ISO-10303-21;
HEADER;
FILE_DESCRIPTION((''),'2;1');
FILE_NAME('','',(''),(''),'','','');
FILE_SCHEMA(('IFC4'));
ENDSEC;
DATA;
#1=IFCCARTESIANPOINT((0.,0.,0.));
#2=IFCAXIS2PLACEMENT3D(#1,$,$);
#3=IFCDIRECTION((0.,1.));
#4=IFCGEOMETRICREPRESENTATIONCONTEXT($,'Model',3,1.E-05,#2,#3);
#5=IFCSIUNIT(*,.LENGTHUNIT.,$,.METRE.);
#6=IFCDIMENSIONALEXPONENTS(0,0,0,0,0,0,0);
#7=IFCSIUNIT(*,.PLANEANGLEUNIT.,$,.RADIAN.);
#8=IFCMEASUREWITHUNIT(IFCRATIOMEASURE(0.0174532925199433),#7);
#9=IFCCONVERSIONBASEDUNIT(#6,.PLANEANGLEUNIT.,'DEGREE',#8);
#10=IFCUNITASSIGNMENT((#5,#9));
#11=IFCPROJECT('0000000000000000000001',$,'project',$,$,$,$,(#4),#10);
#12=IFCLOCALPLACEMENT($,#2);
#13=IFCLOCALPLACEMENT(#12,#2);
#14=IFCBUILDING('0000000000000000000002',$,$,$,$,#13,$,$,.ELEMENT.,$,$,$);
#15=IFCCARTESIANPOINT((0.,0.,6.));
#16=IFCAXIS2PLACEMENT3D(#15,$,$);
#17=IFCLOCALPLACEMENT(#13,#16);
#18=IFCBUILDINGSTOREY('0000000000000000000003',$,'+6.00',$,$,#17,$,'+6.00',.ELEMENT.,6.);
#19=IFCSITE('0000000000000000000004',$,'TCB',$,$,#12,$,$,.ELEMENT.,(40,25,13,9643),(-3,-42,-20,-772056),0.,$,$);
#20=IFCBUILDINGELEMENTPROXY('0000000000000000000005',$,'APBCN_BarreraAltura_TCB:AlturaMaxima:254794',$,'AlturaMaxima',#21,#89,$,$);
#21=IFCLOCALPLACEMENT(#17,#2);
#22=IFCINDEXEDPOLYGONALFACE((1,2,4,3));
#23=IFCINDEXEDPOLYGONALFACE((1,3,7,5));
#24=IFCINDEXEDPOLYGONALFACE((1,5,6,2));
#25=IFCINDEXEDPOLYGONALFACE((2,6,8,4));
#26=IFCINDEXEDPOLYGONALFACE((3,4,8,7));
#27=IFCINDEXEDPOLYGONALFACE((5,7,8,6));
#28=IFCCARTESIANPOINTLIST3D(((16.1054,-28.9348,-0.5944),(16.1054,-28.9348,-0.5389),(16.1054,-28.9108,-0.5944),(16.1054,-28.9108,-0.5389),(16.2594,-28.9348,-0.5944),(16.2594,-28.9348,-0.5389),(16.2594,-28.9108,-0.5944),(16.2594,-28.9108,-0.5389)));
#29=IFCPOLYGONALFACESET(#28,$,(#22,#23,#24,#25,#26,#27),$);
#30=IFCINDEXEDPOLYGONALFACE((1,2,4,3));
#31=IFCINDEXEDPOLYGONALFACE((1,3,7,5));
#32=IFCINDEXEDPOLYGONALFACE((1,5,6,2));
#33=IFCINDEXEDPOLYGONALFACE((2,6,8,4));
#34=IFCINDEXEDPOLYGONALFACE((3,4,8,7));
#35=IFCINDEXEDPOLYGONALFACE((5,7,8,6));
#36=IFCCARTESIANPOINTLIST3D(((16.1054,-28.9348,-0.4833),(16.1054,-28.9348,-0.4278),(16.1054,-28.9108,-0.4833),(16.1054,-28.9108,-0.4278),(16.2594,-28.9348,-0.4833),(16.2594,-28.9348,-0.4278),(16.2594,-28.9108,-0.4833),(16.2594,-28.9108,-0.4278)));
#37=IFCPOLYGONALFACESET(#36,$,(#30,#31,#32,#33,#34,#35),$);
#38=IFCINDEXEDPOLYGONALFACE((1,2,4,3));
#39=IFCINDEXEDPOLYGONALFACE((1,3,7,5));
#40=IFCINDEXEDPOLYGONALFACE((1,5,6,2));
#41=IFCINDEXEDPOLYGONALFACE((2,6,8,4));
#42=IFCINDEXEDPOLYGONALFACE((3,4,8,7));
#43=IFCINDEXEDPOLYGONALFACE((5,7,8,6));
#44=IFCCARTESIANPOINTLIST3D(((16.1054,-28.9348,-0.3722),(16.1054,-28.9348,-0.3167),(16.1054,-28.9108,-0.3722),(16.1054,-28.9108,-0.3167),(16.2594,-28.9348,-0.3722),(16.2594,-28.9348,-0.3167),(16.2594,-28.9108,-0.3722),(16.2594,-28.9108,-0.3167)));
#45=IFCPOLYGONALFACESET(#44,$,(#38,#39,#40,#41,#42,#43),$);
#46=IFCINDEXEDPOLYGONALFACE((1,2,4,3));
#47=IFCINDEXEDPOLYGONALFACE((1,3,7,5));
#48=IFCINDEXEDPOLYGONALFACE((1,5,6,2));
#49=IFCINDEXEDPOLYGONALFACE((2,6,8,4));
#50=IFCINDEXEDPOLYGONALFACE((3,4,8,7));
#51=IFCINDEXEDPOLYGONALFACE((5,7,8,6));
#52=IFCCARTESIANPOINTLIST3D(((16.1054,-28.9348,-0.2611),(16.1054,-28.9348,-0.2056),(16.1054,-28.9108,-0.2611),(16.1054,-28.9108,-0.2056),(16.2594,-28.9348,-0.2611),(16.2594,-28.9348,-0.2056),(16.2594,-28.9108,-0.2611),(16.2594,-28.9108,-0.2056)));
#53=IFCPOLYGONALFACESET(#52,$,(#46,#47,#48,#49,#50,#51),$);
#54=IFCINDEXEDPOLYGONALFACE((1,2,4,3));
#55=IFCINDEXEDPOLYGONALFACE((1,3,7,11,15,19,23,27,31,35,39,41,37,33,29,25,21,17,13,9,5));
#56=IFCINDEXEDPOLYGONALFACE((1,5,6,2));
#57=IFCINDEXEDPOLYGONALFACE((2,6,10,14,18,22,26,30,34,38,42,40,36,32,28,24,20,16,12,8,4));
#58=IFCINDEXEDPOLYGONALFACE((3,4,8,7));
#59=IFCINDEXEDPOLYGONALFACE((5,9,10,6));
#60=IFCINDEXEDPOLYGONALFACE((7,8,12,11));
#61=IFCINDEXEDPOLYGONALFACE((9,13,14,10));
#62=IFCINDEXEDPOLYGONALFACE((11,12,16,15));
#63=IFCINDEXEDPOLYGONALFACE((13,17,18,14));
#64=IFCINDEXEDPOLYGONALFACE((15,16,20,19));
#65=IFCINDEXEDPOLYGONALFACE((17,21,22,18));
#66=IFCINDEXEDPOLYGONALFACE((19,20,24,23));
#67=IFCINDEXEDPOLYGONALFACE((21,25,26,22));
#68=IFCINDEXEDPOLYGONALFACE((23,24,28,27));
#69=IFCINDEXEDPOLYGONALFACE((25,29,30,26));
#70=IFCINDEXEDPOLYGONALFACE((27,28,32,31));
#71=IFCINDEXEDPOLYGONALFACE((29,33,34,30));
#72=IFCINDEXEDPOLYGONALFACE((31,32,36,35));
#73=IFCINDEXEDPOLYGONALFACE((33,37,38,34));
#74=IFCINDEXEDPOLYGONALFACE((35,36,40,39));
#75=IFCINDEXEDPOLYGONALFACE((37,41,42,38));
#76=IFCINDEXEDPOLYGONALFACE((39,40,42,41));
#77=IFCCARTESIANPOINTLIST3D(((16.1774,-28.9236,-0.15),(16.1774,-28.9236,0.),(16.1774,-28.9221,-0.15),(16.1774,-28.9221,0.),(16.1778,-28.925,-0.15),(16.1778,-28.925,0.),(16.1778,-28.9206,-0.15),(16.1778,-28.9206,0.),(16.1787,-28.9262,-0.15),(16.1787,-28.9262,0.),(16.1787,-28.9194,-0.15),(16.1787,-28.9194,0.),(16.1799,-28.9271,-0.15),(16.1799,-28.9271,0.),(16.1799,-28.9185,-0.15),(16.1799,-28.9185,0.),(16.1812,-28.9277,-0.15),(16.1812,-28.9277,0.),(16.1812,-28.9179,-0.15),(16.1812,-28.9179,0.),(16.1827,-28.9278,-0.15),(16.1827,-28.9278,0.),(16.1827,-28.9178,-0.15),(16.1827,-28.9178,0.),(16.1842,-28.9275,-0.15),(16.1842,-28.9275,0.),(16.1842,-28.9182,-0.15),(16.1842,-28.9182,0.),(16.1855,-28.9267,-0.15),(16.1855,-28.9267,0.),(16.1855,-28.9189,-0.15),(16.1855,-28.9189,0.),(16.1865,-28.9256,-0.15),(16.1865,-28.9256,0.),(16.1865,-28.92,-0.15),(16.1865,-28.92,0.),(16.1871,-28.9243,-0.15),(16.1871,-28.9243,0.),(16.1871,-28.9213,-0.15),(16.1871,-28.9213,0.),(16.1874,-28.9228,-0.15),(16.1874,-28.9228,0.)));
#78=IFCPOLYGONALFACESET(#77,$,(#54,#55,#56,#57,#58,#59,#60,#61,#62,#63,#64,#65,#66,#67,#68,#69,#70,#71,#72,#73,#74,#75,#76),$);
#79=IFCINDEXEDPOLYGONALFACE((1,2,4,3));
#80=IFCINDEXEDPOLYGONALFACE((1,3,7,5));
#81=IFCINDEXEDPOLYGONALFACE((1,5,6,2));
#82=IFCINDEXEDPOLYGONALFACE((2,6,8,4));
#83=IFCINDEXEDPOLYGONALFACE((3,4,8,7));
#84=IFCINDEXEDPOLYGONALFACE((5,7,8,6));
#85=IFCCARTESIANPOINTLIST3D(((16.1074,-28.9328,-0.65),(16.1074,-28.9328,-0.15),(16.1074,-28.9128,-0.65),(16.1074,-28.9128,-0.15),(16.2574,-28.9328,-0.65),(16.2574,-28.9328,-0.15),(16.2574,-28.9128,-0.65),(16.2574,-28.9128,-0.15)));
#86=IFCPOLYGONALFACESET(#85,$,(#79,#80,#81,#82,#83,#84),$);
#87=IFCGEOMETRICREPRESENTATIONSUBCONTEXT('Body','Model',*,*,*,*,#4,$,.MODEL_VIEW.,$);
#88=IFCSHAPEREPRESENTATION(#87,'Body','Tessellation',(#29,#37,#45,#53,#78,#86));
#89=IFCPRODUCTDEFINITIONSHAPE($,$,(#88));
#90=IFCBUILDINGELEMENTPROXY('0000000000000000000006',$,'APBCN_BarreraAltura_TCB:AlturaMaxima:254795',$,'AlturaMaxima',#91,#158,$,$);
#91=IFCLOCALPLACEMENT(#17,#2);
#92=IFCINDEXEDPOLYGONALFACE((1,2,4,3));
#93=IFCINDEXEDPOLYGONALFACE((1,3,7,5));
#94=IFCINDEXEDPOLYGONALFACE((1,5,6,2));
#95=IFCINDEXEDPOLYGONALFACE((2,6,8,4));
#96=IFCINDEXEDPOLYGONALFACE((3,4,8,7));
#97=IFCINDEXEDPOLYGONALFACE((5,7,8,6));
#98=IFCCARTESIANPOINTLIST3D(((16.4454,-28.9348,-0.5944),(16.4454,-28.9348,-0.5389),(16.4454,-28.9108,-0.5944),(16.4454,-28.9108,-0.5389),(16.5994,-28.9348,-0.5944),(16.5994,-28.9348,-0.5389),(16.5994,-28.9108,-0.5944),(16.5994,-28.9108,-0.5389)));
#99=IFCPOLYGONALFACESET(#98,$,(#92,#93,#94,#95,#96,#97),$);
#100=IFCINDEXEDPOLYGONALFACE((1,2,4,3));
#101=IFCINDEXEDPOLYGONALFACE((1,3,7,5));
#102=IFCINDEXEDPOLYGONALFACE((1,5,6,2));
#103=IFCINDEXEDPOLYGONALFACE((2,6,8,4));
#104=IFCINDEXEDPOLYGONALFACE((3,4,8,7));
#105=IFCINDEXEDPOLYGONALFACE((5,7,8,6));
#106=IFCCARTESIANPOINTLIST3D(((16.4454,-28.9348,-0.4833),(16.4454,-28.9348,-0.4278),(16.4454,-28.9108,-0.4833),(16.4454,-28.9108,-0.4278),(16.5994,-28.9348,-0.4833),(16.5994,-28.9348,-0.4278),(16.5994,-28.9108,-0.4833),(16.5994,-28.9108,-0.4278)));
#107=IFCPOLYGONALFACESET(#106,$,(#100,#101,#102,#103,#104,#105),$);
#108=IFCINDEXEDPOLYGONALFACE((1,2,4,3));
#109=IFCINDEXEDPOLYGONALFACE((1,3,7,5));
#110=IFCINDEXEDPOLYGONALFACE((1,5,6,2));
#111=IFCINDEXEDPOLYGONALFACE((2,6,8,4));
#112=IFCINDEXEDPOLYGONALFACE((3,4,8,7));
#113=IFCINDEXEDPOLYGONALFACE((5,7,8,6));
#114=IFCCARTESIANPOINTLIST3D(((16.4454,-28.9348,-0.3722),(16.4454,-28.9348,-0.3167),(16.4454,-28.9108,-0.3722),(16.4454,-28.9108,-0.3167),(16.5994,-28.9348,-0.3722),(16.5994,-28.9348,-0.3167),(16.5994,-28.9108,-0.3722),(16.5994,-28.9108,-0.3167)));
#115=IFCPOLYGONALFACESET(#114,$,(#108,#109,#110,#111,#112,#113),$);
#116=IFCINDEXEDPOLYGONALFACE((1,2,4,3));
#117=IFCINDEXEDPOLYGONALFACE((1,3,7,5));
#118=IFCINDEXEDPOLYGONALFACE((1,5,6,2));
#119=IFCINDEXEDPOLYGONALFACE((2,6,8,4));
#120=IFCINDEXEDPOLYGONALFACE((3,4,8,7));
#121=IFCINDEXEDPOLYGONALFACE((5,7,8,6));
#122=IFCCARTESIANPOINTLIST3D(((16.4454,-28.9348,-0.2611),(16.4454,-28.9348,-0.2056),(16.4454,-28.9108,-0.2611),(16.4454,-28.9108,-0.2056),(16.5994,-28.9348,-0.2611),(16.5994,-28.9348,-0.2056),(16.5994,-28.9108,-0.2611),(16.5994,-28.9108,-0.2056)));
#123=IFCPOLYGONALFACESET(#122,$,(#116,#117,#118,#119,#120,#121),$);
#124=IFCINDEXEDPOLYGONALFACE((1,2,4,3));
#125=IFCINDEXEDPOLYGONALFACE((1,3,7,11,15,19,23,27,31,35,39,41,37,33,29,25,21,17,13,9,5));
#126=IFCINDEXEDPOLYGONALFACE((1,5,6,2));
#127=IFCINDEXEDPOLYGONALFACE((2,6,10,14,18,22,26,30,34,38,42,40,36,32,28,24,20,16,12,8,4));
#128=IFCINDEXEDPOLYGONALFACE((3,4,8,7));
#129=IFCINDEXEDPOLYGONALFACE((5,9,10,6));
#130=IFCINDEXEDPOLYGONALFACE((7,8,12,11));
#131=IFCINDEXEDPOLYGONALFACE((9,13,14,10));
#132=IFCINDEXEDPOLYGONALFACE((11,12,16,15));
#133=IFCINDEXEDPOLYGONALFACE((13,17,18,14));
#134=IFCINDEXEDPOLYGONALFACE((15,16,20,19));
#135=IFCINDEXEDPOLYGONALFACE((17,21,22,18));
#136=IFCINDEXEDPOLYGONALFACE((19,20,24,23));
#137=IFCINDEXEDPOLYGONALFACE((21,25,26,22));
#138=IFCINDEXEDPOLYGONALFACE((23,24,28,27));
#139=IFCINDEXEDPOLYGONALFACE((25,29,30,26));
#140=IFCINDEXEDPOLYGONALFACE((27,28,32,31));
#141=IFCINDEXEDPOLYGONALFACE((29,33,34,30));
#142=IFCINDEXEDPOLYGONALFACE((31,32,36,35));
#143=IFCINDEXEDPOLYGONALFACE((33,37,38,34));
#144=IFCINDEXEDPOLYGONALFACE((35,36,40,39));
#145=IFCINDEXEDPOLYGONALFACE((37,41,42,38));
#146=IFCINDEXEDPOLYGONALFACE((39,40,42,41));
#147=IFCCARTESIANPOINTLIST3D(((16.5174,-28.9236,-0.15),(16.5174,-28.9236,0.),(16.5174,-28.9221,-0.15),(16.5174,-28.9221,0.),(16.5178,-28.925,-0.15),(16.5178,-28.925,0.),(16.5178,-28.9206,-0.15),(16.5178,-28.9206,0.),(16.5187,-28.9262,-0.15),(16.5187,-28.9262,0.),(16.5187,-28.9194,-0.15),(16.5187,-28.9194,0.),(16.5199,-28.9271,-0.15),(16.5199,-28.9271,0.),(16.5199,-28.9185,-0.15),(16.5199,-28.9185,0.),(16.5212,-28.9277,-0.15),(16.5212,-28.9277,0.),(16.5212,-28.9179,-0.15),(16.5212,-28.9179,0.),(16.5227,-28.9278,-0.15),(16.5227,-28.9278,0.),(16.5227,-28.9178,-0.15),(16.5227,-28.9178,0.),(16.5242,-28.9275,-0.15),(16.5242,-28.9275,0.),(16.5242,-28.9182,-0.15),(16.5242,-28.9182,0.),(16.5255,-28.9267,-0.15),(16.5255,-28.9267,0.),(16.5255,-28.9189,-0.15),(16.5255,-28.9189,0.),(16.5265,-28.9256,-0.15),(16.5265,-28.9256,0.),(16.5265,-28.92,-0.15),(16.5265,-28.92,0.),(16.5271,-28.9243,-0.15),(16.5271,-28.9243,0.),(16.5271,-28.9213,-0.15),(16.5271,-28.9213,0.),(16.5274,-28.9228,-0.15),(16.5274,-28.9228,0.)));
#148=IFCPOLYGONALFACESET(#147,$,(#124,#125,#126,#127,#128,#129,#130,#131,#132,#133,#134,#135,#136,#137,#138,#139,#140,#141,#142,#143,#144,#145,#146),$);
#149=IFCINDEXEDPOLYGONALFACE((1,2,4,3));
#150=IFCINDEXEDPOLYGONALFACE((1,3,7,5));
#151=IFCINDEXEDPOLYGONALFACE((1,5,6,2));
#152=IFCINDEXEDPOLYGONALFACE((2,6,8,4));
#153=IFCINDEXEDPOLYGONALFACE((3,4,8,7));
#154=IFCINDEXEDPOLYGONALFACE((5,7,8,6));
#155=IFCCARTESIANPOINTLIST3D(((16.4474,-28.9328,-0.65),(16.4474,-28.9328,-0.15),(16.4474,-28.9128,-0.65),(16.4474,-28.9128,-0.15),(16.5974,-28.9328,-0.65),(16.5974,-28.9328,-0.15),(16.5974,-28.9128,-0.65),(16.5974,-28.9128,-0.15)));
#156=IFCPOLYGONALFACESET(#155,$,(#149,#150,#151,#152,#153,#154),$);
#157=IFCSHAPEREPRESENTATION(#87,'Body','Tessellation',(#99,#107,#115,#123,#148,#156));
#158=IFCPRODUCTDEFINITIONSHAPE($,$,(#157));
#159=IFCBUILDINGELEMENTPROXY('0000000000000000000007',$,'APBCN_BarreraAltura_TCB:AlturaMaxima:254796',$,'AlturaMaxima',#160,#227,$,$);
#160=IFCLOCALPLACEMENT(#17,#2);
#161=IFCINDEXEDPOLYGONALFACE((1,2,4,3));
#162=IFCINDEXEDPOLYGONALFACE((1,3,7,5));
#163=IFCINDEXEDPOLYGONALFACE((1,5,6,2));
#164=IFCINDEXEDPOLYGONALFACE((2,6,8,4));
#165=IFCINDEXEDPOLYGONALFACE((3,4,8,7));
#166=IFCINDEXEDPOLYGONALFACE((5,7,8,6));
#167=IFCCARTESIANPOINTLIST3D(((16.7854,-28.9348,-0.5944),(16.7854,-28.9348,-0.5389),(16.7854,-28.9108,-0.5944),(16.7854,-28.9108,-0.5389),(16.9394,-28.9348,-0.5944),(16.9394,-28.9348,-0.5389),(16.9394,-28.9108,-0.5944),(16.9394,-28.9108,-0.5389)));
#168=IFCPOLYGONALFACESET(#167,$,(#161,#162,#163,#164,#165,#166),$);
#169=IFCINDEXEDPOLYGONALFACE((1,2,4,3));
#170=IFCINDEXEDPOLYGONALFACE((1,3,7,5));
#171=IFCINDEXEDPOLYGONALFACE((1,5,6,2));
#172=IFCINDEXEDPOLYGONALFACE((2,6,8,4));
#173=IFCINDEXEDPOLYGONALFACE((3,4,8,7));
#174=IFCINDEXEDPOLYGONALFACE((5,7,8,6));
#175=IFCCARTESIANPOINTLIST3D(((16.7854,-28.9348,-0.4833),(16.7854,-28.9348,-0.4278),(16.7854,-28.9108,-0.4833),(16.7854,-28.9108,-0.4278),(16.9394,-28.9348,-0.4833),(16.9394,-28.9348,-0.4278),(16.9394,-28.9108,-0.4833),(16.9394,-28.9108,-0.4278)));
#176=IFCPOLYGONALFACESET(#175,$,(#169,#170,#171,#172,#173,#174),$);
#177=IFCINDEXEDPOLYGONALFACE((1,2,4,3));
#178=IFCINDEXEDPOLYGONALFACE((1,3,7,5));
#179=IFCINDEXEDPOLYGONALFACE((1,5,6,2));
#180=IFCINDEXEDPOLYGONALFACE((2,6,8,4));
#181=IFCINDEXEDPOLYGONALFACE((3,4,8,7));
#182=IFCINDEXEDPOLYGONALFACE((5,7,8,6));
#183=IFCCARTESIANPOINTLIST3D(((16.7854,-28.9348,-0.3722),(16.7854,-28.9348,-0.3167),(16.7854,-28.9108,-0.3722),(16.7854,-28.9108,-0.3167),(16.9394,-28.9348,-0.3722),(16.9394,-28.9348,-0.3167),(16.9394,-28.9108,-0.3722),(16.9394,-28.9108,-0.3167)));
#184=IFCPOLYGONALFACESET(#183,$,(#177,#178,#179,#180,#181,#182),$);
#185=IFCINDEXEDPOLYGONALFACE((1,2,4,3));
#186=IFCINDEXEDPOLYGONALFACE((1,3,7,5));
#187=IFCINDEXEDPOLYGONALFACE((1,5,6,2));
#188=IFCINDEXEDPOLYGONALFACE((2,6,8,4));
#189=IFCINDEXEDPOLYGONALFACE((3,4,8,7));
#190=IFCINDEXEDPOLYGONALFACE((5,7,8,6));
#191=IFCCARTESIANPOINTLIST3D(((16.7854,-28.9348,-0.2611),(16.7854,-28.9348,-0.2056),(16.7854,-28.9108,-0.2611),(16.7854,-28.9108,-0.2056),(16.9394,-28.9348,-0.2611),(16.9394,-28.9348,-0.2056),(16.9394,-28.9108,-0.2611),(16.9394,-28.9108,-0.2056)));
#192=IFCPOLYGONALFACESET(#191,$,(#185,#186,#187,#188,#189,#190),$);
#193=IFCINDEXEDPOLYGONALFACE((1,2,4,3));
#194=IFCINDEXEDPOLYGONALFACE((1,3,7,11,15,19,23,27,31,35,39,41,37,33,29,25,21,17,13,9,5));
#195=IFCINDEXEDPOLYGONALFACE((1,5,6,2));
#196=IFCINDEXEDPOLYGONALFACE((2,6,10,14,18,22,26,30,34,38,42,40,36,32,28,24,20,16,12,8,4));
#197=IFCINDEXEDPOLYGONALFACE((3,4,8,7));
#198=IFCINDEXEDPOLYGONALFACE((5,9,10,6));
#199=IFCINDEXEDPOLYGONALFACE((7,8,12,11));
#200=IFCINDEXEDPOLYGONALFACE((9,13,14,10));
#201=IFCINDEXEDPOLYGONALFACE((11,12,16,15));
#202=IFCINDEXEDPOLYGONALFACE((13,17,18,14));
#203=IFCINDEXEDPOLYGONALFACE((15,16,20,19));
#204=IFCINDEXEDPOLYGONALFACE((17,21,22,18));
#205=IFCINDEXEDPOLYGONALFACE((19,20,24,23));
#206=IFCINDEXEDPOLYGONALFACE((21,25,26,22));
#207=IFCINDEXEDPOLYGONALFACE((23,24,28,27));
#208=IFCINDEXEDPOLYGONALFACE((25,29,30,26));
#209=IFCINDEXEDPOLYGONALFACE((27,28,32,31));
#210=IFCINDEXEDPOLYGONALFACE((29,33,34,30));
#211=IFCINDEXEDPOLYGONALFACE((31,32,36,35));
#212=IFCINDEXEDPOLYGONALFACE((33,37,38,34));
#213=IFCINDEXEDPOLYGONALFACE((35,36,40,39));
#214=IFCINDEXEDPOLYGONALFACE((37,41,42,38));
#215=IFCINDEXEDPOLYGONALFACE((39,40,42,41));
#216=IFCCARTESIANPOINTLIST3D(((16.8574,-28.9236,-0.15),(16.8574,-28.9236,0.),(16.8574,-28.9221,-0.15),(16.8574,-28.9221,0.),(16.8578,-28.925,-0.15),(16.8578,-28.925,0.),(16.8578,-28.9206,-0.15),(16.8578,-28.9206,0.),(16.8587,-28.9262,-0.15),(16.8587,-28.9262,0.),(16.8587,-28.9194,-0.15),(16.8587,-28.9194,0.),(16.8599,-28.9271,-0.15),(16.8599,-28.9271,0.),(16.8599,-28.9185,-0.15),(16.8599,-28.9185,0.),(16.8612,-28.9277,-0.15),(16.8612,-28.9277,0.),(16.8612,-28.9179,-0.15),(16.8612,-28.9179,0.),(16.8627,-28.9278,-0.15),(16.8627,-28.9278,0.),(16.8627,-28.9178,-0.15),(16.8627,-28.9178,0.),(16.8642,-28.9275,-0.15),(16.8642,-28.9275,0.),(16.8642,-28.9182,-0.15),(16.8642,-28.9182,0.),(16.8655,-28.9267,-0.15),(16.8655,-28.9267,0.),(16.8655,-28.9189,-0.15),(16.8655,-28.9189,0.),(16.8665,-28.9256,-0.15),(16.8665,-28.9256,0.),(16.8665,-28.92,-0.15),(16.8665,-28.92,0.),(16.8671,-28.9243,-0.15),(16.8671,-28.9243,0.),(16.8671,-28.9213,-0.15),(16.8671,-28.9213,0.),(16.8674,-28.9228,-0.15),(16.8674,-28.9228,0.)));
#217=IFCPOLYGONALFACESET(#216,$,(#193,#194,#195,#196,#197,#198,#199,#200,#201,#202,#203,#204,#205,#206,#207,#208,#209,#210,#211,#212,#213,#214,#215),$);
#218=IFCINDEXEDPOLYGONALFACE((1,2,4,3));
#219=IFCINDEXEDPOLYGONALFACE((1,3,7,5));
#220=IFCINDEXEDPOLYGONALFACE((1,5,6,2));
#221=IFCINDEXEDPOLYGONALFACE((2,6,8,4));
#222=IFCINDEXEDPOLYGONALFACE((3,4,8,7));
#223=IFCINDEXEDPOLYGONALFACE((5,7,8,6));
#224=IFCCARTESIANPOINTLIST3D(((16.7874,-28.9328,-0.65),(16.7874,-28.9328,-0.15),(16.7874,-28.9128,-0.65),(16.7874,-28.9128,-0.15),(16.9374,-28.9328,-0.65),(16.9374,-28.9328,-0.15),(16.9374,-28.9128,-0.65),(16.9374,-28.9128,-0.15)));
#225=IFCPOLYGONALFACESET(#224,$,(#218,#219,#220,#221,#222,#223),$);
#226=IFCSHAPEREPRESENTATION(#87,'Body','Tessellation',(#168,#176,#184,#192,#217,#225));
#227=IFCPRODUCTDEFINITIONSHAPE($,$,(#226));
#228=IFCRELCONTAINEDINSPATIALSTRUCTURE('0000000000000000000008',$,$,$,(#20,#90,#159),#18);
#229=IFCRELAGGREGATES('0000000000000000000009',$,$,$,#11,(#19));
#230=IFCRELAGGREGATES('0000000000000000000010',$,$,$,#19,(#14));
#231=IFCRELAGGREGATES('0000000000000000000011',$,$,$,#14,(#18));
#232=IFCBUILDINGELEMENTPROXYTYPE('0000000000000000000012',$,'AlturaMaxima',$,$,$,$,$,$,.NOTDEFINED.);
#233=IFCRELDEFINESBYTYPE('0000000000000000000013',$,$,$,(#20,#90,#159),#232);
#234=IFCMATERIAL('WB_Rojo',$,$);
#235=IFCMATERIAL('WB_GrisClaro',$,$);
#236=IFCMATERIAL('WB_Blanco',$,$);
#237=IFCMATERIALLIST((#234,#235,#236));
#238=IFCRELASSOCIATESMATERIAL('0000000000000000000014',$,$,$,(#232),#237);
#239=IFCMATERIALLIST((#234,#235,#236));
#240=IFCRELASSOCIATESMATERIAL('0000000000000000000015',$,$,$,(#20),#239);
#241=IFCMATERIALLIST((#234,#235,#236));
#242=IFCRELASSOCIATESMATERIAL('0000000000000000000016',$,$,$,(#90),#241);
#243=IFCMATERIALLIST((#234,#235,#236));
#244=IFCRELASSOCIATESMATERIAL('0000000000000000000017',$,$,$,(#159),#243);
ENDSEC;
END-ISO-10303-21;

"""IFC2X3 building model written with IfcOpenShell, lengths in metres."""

from ifc_helpers import new_model, entity, si_unit, converted_unit, direction, frame, frame_2d, origin, origin_2d_with_axis, place, context, subcontext, project, spatial, rectangle, circle, extrude, source, transform, mapped, material, material_list, type_object, type_shapes, element, save


model = new_model("IFC2X3")

# Units and contexts
model_context = context("Model", 3, precision=1e-05, world=origin(), true_north=direction((0.0, 1.0)))
body_context = subcontext(model_context, "Body", "Model", "MODEL_VIEW")
ifc_project = project(units=[si_unit("LENGTHUNIT", "METRE"), converted_unit("PLANEANGLEUNIT", "DEGREE", entity("IfcRatioMeasure", 0.0174532925199433), si_unit("PLANEANGLEUNIT", "RADIAN"), dimensions=[0, 0, 0, 0, 0, 0, 0])], contexts=[model_context])

# Site, building, storey
site_placement = place(None, origin())
site = spatial("IfcSite", under=ifc_project, at=site_placement, Name="TCB", CompositionType="ELEMENT", RefLatitude=(40, 25, 13, 9643), RefLongitude=(-3, -42, -20, -772056), RefElevation=0.0)
building_placement = place(site_placement, origin())
building = spatial("IfcBuilding", under=site, at=building_placement, CompositionType="ELEMENT")
storey_placement = place(building_placement, frame((0.0, 0.0, 6.0)))
storey = spatial("IfcBuildingStorey", under=building, at=storey_placement, Name="+6.00", LongName="+6.00", CompositionType="ELEMENT", Elevation=6.0)

# Building element proxies
ifc_material_1 = material(Name="WB_Rojo")
ifc_material_2 = material(Name="WB_GrisClaro")
ifc_material_3 = material(Name="WB_Blanco")
ifc_material_list_1 = material_list([ifc_material_1, ifc_material_2, ifc_material_3])
ifc_material_list_2 = material_list([ifc_material_1, ifc_material_2, ifc_material_3])
building_element_proxy_type = type_object("IfcBuildingElementProxyType", Name="AlturaMaxima", PredefinedType="NOTDEFINED", material=ifc_material_list_2)
shared_shape = source(origin(), body_context, "Body", "SweptSolid", [
    extrude(rectangle(XDim=0.154, YDim=0.024, at=frame_2d((0.0, 0.0), x_axis=(1.0, 0.0))), frame((0.0, 0.0, -0.5944), z_axis=(0.0, 0.0, 1.0), x_axis=(-1.0, 0.0, 0.0)), (0.0, 0.0, 1.0), 0.0556),
    extrude(rectangle(XDim=0.154, YDim=0.024, at=frame_2d((0.0, 0.0), x_axis=(1.0, 0.0))), frame((0.0, 0.0, -0.4833), z_axis=(0.0, 0.0, 1.0), x_axis=(-1.0, 0.0, 0.0)), (0.0, 0.0, 1.0), 0.0556),
    extrude(rectangle(XDim=0.154, YDim=0.024, at=frame_2d((0.0, 0.0), x_axis=(1.0, 0.0))), frame((0.0, 0.0, -0.3722), z_axis=(0.0, 0.0, 1.0), x_axis=(-1.0, 0.0, 0.0)), (0.0, 0.0, 1.0), 0.0556),
    extrude(rectangle(XDim=0.154, YDim=0.024, at=frame_2d((0.0, 0.0), x_axis=(1.0, 0.0))), frame((0.0, 0.0, -0.2611), z_axis=(0.0, 0.0, 1.0), x_axis=(-1.0, 0.0, 0.0)), (0.0, 0.0, 1.0), 0.0556),
    extrude(circle(Radius=0.005, at=frame_2d((0.0, 0.0), x_axis=(1.0, 0.0))), frame((0.0, 0.0, -0.15)), (0.0, 0.0, 1.0), 0.15),
    extrude(rectangle(XDim=0.02, YDim=0.15, at=origin_2d_with_axis()), frame((0.0, 0.0, -0.65), z_axis=(0.0, 0.0, 1.0), x_axis=(0.0, 1.0, 0.0)), (0.0, 0.0, 1.0), 0.5),
])
type_shapes(building_element_proxy_type, [shared_shape])
proxy_1_placement = place(storey_placement, frame((16.1824, -28.9228, 0.0)))
element("IfcBuildingElementProxy", 1, at=proxy_1_placement, inside=storey, type_object=building_element_proxy_type, material=ifc_material_list_1, Name="APBCN_BarreraAltura_TCB:AlturaMaxima:254794", ObjectType="AlturaMaxima", context=body_context, shape_type="MappedRepresentation", body=[
    mapped(shared_shape, transform((0.0, 0.0, 0.0), scale=1.0)),
])
ifc_material_list_3 = material_list([ifc_material_1, ifc_material_2, ifc_material_3])
proxy_2_placement = place(storey_placement, frame((16.5224, -28.9228, 0.0)))
element("IfcBuildingElementProxy", 2, at=proxy_2_placement, inside=storey, type_object=building_element_proxy_type, material=ifc_material_list_3, Name="APBCN_BarreraAltura_TCB:AlturaMaxima:254795", ObjectType="AlturaMaxima", context=body_context, shape_type="MappedRepresentation", body=[
    mapped(shared_shape, transform((0.0, 0.0, 0.0), scale=1.0)),
])
ifc_material_list_4 = material_list([ifc_material_1, ifc_material_2, ifc_material_3])
proxy_3_placement = place(storey_placement, frame((16.8624, -28.9228, 0.0)))
element("IfcBuildingElementProxy", 3, at=proxy_3_placement, inside=storey, type_object=building_element_proxy_type, material=ifc_material_list_4, Name="APBCN_BarreraAltura_TCB:AlturaMaxima:254796", ObjectType="AlturaMaxima", context=body_context, shape_type="MappedRepresentation", body=[
    mapped(shared_shape, transform((0.0, 0.0, 0.0), scale=1.0)),
])

save(model, "model.ifc")
